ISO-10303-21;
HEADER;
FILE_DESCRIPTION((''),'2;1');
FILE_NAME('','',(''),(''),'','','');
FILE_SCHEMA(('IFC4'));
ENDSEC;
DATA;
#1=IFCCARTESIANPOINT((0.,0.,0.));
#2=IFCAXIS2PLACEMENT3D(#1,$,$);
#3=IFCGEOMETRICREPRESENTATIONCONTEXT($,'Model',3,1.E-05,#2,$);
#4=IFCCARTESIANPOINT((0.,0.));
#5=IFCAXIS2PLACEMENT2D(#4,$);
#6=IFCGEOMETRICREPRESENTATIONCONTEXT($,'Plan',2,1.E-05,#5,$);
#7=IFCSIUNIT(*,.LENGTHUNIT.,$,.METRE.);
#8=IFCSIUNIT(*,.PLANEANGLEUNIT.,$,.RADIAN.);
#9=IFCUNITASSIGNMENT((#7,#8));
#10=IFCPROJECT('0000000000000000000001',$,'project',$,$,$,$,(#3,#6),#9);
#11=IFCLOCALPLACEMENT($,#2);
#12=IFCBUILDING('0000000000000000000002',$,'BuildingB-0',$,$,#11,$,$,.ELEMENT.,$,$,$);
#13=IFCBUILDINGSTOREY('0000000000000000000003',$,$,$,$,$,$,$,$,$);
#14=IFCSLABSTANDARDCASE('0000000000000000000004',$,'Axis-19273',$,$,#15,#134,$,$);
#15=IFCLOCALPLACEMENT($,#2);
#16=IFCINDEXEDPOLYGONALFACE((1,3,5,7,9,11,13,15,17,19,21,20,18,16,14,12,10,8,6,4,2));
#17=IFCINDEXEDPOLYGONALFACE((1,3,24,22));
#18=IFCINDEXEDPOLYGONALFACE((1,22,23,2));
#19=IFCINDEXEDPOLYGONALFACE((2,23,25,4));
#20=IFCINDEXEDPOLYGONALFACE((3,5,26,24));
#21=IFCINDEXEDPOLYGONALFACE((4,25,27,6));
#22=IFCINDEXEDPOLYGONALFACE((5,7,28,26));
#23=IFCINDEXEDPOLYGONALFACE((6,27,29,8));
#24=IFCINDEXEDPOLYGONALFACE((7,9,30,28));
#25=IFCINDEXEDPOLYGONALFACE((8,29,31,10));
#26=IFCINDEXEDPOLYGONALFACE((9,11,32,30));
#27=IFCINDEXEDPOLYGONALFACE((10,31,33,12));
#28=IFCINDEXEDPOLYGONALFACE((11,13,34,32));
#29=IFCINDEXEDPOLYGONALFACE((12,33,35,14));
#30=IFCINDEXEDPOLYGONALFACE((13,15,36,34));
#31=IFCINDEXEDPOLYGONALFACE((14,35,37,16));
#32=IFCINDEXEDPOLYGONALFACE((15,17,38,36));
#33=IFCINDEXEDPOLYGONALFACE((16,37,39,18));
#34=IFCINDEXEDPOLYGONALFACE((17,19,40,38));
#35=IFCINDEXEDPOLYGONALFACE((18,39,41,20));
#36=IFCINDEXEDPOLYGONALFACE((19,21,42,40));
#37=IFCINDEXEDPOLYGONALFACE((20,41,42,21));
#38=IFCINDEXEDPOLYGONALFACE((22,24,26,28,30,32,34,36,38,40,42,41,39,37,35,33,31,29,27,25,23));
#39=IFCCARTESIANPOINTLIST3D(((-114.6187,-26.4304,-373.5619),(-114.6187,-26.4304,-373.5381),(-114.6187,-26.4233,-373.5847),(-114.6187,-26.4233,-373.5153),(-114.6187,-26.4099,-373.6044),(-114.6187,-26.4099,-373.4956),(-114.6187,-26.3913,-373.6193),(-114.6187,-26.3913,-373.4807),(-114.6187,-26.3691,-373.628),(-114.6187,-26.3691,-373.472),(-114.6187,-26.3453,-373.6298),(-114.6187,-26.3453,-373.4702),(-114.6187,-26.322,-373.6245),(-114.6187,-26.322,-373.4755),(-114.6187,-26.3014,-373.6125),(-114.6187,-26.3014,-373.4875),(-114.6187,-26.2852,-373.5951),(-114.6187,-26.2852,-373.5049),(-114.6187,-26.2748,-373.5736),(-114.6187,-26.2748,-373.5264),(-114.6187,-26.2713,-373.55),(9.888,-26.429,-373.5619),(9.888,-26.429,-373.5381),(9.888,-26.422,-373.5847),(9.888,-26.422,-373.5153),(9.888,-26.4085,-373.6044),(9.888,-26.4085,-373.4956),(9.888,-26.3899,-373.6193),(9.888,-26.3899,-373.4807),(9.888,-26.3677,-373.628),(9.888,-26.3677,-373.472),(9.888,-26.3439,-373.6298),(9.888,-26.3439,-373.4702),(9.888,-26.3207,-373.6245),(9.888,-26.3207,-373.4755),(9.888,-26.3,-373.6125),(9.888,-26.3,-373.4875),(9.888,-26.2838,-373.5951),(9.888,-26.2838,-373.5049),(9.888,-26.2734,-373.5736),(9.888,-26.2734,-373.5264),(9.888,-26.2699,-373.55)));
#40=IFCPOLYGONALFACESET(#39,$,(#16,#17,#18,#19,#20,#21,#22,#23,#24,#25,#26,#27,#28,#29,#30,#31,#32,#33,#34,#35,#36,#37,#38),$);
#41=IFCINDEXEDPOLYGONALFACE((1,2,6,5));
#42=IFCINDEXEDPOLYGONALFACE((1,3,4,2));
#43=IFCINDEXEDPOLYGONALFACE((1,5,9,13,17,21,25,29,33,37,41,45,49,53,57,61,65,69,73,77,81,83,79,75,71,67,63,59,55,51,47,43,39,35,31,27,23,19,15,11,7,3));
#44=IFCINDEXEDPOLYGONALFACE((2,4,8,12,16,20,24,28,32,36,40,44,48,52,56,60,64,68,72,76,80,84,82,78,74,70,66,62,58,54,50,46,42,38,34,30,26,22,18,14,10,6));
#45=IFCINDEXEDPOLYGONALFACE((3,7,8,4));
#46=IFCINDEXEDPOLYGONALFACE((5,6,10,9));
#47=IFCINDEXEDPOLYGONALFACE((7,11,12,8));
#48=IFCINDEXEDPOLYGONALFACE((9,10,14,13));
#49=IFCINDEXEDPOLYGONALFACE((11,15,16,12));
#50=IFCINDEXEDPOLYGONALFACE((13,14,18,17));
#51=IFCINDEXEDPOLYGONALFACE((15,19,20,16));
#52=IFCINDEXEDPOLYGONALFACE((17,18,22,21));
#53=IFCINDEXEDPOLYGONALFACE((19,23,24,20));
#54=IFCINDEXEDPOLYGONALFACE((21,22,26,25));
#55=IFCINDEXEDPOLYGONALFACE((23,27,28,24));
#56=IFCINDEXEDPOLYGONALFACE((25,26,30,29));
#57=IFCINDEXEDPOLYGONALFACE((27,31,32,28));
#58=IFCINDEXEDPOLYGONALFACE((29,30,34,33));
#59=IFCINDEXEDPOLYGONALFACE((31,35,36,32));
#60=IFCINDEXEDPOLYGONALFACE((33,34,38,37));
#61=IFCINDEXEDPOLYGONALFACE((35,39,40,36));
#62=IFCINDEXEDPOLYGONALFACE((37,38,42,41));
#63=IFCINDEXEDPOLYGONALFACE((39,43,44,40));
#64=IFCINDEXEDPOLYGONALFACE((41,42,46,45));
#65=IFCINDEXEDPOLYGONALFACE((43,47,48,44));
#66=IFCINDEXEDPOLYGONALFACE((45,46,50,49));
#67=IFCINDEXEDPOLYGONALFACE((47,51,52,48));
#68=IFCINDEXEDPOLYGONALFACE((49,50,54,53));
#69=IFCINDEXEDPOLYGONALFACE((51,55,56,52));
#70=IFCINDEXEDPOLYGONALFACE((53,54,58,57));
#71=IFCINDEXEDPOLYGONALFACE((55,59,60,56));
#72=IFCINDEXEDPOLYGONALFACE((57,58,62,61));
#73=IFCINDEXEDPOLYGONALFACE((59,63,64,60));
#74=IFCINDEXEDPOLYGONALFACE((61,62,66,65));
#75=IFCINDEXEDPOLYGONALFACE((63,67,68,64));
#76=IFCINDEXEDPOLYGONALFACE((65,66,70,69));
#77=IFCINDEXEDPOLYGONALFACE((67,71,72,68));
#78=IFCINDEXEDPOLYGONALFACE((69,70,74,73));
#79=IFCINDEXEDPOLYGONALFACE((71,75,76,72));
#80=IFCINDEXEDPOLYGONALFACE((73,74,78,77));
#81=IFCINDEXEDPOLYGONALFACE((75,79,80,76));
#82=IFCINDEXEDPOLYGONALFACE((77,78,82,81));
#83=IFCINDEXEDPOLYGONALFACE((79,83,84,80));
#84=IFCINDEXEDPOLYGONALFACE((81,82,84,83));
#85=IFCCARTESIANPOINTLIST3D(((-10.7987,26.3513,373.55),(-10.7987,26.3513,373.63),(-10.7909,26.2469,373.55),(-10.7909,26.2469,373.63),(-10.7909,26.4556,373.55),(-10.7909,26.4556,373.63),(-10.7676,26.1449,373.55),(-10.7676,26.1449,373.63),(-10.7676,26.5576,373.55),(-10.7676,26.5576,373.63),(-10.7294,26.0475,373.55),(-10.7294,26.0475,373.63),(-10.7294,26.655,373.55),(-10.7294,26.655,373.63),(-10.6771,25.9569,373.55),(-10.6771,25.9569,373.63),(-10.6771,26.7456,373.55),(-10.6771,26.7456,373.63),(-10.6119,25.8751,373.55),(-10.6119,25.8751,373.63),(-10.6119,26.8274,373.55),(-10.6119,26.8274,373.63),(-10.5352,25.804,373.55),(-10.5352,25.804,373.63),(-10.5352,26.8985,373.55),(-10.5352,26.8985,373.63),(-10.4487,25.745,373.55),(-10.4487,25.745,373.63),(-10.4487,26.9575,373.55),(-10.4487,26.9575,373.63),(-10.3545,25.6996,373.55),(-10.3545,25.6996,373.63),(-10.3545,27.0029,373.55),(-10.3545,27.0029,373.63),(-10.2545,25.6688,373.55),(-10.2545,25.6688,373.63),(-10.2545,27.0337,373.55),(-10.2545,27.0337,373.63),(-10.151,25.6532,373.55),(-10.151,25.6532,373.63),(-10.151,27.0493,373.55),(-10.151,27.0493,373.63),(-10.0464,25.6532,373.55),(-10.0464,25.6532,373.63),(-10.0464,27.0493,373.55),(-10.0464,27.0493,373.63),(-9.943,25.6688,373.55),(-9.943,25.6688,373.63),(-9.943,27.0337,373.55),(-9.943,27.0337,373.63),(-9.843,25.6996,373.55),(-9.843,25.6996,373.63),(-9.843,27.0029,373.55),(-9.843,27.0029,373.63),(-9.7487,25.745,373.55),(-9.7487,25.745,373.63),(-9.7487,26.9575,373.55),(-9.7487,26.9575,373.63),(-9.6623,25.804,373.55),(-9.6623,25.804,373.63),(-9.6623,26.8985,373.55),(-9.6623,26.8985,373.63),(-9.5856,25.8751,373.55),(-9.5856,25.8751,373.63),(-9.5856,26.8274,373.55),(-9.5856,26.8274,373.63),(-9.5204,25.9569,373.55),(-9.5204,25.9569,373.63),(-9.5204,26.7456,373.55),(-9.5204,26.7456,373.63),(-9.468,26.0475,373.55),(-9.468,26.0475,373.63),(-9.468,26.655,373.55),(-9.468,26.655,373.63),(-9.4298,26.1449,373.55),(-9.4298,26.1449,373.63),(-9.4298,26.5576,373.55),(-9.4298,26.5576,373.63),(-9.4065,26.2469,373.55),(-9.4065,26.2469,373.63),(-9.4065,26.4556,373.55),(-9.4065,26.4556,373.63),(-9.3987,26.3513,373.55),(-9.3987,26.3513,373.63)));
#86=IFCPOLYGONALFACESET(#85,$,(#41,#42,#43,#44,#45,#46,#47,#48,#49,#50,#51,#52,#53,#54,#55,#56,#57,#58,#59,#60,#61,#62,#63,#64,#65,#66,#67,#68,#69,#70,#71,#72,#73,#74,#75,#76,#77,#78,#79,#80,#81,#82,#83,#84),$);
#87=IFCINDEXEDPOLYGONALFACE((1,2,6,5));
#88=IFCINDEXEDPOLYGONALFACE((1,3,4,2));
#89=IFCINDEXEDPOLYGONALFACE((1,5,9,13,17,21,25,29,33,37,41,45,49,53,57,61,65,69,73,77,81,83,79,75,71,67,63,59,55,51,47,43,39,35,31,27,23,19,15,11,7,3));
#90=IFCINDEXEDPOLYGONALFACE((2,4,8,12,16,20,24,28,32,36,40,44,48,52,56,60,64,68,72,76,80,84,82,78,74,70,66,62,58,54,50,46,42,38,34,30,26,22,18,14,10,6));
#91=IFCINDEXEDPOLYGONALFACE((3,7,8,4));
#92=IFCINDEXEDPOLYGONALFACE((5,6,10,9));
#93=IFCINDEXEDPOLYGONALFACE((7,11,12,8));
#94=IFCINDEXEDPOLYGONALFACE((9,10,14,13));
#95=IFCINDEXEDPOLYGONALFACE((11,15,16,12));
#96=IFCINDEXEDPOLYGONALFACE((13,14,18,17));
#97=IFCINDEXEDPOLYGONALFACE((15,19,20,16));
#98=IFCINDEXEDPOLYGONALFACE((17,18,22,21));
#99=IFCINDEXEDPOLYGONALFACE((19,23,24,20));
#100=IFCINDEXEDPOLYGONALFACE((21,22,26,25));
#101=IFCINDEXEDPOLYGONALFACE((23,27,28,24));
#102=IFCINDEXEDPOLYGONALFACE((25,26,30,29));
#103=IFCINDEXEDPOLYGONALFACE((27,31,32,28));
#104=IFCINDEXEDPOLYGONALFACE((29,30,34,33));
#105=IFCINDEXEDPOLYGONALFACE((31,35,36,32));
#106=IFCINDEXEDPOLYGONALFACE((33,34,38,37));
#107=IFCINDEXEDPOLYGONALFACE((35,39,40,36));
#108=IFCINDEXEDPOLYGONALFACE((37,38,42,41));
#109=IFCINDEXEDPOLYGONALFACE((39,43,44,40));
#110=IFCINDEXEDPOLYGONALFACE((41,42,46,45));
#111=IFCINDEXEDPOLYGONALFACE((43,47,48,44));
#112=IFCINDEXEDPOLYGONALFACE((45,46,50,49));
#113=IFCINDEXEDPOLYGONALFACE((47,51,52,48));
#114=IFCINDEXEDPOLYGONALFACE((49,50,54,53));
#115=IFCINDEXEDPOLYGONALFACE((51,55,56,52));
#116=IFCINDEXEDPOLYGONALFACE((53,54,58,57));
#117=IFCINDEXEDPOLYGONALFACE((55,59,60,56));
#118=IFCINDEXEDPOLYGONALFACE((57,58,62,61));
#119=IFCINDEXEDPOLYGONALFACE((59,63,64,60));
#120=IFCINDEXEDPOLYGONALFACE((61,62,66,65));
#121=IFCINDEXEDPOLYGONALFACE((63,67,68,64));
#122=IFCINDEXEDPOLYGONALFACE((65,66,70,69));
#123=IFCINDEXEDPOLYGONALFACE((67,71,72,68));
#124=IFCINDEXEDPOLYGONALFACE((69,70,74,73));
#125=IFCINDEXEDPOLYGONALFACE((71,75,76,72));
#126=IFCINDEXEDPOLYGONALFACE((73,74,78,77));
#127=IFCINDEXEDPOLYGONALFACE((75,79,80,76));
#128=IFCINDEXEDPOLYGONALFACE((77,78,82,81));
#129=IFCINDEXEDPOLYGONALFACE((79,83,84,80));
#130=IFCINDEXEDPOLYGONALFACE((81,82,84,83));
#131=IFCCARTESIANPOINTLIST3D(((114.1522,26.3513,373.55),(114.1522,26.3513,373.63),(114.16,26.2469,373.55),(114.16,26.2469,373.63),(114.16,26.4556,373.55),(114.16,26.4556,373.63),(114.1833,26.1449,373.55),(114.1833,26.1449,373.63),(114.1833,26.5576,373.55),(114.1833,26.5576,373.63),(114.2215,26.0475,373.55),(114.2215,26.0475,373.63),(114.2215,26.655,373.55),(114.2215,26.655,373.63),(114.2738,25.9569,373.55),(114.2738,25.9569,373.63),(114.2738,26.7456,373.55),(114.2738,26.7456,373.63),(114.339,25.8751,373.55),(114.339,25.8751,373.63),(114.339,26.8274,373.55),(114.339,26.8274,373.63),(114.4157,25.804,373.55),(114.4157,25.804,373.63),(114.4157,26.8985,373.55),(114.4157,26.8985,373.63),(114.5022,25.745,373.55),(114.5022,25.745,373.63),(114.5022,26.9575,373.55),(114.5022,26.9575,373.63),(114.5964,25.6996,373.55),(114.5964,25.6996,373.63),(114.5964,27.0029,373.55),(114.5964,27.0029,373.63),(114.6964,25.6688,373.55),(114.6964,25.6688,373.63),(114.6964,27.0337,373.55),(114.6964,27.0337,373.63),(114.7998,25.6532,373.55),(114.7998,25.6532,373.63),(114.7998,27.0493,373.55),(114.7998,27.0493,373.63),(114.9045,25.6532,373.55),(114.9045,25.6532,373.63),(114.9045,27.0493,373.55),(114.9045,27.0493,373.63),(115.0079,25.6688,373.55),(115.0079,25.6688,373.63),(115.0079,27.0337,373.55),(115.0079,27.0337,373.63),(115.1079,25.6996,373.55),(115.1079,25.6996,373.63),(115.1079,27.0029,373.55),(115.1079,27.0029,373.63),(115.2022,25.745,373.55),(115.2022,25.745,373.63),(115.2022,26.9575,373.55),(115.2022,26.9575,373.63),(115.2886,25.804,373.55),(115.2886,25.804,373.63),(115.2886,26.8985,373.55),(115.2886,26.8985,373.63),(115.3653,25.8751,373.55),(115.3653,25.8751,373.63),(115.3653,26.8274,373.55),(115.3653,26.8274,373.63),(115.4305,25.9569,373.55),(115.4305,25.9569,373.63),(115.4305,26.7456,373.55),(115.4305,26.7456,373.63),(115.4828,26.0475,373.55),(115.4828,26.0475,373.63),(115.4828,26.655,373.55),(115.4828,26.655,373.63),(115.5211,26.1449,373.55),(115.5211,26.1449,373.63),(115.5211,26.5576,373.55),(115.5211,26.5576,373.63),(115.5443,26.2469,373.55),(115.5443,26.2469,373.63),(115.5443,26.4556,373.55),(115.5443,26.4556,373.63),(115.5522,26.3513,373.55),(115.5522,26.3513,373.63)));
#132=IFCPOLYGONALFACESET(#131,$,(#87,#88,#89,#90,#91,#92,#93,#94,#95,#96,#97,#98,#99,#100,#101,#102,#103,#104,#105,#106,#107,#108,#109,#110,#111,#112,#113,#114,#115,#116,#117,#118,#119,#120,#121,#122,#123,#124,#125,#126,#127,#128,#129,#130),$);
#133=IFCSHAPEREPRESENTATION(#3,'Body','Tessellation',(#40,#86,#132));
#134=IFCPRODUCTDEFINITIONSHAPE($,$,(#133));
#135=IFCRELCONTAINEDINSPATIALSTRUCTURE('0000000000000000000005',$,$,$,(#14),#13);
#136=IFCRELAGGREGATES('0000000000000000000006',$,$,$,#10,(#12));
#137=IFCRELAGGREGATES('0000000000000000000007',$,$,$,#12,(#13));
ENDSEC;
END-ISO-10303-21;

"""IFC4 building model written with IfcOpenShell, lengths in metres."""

from ifc_helpers import new_model, entity, si_unit, frame, origin, origin_2d, place, context, project, spatial, circle, extrude, element, save


model = new_model("IFC4")

# Units and contexts
model_context = context("Model", 3, precision=1e-05, world=origin())
plan_context = context("Plan", 2, precision=1e-05, world=origin_2d())
ifc_project = project(units=[si_unit("LENGTHUNIT", "METRE"), si_unit("PLANEANGLEUNIT", "RADIAN")], contexts=[model_context, plan_context])

# Building, storey
building_placement = place(None, origin())
building = spatial("IfcBuilding", under=ifc_project, at=building_placement, Name="BuildingB-0", CompositionType="ELEMENT")
storey = spatial("IfcBuildingStorey", under=building)

# Slab
element("IfcSlabStandardCase", 1, inside=storey, Name="Axis-19273", context=model_context, shape_type="AdvancedSweptSolid", body=[
    entity("IfcSurfaceCurveSweptAreaSolid", entity("IfcCircleProfileDef", "AREA", None, None, 0.08), None, entity("IfcPolyline", [entity("IfcCartesianPoint", [-9.888, 26.3499, 373.55]), entity("IfcCartesianPoint", [114.6187, 26.3513, 373.55])]), None, None, entity("IfcPlane", entity("IfcAxis2Placement3D", entity("IfcCartesianPoint", [-9.888, 26.3499, 373.55]), entity("IfcDirection", [0.0, 0.0, 1.0]), entity("IfcDirection", [1.0, 0.0, 0.0])))),
    extrude(circle(Radius=0.7), frame((-10.0987, 26.3513, 373.55)), (0.0, 0.0, 1.0), 0.08),
    extrude(circle(Radius=0.7), frame((114.8522, 26.3513, 373.55)), (0.0, 0.0, 1.0), 0.08),
])

save(model, "model.ifc")
